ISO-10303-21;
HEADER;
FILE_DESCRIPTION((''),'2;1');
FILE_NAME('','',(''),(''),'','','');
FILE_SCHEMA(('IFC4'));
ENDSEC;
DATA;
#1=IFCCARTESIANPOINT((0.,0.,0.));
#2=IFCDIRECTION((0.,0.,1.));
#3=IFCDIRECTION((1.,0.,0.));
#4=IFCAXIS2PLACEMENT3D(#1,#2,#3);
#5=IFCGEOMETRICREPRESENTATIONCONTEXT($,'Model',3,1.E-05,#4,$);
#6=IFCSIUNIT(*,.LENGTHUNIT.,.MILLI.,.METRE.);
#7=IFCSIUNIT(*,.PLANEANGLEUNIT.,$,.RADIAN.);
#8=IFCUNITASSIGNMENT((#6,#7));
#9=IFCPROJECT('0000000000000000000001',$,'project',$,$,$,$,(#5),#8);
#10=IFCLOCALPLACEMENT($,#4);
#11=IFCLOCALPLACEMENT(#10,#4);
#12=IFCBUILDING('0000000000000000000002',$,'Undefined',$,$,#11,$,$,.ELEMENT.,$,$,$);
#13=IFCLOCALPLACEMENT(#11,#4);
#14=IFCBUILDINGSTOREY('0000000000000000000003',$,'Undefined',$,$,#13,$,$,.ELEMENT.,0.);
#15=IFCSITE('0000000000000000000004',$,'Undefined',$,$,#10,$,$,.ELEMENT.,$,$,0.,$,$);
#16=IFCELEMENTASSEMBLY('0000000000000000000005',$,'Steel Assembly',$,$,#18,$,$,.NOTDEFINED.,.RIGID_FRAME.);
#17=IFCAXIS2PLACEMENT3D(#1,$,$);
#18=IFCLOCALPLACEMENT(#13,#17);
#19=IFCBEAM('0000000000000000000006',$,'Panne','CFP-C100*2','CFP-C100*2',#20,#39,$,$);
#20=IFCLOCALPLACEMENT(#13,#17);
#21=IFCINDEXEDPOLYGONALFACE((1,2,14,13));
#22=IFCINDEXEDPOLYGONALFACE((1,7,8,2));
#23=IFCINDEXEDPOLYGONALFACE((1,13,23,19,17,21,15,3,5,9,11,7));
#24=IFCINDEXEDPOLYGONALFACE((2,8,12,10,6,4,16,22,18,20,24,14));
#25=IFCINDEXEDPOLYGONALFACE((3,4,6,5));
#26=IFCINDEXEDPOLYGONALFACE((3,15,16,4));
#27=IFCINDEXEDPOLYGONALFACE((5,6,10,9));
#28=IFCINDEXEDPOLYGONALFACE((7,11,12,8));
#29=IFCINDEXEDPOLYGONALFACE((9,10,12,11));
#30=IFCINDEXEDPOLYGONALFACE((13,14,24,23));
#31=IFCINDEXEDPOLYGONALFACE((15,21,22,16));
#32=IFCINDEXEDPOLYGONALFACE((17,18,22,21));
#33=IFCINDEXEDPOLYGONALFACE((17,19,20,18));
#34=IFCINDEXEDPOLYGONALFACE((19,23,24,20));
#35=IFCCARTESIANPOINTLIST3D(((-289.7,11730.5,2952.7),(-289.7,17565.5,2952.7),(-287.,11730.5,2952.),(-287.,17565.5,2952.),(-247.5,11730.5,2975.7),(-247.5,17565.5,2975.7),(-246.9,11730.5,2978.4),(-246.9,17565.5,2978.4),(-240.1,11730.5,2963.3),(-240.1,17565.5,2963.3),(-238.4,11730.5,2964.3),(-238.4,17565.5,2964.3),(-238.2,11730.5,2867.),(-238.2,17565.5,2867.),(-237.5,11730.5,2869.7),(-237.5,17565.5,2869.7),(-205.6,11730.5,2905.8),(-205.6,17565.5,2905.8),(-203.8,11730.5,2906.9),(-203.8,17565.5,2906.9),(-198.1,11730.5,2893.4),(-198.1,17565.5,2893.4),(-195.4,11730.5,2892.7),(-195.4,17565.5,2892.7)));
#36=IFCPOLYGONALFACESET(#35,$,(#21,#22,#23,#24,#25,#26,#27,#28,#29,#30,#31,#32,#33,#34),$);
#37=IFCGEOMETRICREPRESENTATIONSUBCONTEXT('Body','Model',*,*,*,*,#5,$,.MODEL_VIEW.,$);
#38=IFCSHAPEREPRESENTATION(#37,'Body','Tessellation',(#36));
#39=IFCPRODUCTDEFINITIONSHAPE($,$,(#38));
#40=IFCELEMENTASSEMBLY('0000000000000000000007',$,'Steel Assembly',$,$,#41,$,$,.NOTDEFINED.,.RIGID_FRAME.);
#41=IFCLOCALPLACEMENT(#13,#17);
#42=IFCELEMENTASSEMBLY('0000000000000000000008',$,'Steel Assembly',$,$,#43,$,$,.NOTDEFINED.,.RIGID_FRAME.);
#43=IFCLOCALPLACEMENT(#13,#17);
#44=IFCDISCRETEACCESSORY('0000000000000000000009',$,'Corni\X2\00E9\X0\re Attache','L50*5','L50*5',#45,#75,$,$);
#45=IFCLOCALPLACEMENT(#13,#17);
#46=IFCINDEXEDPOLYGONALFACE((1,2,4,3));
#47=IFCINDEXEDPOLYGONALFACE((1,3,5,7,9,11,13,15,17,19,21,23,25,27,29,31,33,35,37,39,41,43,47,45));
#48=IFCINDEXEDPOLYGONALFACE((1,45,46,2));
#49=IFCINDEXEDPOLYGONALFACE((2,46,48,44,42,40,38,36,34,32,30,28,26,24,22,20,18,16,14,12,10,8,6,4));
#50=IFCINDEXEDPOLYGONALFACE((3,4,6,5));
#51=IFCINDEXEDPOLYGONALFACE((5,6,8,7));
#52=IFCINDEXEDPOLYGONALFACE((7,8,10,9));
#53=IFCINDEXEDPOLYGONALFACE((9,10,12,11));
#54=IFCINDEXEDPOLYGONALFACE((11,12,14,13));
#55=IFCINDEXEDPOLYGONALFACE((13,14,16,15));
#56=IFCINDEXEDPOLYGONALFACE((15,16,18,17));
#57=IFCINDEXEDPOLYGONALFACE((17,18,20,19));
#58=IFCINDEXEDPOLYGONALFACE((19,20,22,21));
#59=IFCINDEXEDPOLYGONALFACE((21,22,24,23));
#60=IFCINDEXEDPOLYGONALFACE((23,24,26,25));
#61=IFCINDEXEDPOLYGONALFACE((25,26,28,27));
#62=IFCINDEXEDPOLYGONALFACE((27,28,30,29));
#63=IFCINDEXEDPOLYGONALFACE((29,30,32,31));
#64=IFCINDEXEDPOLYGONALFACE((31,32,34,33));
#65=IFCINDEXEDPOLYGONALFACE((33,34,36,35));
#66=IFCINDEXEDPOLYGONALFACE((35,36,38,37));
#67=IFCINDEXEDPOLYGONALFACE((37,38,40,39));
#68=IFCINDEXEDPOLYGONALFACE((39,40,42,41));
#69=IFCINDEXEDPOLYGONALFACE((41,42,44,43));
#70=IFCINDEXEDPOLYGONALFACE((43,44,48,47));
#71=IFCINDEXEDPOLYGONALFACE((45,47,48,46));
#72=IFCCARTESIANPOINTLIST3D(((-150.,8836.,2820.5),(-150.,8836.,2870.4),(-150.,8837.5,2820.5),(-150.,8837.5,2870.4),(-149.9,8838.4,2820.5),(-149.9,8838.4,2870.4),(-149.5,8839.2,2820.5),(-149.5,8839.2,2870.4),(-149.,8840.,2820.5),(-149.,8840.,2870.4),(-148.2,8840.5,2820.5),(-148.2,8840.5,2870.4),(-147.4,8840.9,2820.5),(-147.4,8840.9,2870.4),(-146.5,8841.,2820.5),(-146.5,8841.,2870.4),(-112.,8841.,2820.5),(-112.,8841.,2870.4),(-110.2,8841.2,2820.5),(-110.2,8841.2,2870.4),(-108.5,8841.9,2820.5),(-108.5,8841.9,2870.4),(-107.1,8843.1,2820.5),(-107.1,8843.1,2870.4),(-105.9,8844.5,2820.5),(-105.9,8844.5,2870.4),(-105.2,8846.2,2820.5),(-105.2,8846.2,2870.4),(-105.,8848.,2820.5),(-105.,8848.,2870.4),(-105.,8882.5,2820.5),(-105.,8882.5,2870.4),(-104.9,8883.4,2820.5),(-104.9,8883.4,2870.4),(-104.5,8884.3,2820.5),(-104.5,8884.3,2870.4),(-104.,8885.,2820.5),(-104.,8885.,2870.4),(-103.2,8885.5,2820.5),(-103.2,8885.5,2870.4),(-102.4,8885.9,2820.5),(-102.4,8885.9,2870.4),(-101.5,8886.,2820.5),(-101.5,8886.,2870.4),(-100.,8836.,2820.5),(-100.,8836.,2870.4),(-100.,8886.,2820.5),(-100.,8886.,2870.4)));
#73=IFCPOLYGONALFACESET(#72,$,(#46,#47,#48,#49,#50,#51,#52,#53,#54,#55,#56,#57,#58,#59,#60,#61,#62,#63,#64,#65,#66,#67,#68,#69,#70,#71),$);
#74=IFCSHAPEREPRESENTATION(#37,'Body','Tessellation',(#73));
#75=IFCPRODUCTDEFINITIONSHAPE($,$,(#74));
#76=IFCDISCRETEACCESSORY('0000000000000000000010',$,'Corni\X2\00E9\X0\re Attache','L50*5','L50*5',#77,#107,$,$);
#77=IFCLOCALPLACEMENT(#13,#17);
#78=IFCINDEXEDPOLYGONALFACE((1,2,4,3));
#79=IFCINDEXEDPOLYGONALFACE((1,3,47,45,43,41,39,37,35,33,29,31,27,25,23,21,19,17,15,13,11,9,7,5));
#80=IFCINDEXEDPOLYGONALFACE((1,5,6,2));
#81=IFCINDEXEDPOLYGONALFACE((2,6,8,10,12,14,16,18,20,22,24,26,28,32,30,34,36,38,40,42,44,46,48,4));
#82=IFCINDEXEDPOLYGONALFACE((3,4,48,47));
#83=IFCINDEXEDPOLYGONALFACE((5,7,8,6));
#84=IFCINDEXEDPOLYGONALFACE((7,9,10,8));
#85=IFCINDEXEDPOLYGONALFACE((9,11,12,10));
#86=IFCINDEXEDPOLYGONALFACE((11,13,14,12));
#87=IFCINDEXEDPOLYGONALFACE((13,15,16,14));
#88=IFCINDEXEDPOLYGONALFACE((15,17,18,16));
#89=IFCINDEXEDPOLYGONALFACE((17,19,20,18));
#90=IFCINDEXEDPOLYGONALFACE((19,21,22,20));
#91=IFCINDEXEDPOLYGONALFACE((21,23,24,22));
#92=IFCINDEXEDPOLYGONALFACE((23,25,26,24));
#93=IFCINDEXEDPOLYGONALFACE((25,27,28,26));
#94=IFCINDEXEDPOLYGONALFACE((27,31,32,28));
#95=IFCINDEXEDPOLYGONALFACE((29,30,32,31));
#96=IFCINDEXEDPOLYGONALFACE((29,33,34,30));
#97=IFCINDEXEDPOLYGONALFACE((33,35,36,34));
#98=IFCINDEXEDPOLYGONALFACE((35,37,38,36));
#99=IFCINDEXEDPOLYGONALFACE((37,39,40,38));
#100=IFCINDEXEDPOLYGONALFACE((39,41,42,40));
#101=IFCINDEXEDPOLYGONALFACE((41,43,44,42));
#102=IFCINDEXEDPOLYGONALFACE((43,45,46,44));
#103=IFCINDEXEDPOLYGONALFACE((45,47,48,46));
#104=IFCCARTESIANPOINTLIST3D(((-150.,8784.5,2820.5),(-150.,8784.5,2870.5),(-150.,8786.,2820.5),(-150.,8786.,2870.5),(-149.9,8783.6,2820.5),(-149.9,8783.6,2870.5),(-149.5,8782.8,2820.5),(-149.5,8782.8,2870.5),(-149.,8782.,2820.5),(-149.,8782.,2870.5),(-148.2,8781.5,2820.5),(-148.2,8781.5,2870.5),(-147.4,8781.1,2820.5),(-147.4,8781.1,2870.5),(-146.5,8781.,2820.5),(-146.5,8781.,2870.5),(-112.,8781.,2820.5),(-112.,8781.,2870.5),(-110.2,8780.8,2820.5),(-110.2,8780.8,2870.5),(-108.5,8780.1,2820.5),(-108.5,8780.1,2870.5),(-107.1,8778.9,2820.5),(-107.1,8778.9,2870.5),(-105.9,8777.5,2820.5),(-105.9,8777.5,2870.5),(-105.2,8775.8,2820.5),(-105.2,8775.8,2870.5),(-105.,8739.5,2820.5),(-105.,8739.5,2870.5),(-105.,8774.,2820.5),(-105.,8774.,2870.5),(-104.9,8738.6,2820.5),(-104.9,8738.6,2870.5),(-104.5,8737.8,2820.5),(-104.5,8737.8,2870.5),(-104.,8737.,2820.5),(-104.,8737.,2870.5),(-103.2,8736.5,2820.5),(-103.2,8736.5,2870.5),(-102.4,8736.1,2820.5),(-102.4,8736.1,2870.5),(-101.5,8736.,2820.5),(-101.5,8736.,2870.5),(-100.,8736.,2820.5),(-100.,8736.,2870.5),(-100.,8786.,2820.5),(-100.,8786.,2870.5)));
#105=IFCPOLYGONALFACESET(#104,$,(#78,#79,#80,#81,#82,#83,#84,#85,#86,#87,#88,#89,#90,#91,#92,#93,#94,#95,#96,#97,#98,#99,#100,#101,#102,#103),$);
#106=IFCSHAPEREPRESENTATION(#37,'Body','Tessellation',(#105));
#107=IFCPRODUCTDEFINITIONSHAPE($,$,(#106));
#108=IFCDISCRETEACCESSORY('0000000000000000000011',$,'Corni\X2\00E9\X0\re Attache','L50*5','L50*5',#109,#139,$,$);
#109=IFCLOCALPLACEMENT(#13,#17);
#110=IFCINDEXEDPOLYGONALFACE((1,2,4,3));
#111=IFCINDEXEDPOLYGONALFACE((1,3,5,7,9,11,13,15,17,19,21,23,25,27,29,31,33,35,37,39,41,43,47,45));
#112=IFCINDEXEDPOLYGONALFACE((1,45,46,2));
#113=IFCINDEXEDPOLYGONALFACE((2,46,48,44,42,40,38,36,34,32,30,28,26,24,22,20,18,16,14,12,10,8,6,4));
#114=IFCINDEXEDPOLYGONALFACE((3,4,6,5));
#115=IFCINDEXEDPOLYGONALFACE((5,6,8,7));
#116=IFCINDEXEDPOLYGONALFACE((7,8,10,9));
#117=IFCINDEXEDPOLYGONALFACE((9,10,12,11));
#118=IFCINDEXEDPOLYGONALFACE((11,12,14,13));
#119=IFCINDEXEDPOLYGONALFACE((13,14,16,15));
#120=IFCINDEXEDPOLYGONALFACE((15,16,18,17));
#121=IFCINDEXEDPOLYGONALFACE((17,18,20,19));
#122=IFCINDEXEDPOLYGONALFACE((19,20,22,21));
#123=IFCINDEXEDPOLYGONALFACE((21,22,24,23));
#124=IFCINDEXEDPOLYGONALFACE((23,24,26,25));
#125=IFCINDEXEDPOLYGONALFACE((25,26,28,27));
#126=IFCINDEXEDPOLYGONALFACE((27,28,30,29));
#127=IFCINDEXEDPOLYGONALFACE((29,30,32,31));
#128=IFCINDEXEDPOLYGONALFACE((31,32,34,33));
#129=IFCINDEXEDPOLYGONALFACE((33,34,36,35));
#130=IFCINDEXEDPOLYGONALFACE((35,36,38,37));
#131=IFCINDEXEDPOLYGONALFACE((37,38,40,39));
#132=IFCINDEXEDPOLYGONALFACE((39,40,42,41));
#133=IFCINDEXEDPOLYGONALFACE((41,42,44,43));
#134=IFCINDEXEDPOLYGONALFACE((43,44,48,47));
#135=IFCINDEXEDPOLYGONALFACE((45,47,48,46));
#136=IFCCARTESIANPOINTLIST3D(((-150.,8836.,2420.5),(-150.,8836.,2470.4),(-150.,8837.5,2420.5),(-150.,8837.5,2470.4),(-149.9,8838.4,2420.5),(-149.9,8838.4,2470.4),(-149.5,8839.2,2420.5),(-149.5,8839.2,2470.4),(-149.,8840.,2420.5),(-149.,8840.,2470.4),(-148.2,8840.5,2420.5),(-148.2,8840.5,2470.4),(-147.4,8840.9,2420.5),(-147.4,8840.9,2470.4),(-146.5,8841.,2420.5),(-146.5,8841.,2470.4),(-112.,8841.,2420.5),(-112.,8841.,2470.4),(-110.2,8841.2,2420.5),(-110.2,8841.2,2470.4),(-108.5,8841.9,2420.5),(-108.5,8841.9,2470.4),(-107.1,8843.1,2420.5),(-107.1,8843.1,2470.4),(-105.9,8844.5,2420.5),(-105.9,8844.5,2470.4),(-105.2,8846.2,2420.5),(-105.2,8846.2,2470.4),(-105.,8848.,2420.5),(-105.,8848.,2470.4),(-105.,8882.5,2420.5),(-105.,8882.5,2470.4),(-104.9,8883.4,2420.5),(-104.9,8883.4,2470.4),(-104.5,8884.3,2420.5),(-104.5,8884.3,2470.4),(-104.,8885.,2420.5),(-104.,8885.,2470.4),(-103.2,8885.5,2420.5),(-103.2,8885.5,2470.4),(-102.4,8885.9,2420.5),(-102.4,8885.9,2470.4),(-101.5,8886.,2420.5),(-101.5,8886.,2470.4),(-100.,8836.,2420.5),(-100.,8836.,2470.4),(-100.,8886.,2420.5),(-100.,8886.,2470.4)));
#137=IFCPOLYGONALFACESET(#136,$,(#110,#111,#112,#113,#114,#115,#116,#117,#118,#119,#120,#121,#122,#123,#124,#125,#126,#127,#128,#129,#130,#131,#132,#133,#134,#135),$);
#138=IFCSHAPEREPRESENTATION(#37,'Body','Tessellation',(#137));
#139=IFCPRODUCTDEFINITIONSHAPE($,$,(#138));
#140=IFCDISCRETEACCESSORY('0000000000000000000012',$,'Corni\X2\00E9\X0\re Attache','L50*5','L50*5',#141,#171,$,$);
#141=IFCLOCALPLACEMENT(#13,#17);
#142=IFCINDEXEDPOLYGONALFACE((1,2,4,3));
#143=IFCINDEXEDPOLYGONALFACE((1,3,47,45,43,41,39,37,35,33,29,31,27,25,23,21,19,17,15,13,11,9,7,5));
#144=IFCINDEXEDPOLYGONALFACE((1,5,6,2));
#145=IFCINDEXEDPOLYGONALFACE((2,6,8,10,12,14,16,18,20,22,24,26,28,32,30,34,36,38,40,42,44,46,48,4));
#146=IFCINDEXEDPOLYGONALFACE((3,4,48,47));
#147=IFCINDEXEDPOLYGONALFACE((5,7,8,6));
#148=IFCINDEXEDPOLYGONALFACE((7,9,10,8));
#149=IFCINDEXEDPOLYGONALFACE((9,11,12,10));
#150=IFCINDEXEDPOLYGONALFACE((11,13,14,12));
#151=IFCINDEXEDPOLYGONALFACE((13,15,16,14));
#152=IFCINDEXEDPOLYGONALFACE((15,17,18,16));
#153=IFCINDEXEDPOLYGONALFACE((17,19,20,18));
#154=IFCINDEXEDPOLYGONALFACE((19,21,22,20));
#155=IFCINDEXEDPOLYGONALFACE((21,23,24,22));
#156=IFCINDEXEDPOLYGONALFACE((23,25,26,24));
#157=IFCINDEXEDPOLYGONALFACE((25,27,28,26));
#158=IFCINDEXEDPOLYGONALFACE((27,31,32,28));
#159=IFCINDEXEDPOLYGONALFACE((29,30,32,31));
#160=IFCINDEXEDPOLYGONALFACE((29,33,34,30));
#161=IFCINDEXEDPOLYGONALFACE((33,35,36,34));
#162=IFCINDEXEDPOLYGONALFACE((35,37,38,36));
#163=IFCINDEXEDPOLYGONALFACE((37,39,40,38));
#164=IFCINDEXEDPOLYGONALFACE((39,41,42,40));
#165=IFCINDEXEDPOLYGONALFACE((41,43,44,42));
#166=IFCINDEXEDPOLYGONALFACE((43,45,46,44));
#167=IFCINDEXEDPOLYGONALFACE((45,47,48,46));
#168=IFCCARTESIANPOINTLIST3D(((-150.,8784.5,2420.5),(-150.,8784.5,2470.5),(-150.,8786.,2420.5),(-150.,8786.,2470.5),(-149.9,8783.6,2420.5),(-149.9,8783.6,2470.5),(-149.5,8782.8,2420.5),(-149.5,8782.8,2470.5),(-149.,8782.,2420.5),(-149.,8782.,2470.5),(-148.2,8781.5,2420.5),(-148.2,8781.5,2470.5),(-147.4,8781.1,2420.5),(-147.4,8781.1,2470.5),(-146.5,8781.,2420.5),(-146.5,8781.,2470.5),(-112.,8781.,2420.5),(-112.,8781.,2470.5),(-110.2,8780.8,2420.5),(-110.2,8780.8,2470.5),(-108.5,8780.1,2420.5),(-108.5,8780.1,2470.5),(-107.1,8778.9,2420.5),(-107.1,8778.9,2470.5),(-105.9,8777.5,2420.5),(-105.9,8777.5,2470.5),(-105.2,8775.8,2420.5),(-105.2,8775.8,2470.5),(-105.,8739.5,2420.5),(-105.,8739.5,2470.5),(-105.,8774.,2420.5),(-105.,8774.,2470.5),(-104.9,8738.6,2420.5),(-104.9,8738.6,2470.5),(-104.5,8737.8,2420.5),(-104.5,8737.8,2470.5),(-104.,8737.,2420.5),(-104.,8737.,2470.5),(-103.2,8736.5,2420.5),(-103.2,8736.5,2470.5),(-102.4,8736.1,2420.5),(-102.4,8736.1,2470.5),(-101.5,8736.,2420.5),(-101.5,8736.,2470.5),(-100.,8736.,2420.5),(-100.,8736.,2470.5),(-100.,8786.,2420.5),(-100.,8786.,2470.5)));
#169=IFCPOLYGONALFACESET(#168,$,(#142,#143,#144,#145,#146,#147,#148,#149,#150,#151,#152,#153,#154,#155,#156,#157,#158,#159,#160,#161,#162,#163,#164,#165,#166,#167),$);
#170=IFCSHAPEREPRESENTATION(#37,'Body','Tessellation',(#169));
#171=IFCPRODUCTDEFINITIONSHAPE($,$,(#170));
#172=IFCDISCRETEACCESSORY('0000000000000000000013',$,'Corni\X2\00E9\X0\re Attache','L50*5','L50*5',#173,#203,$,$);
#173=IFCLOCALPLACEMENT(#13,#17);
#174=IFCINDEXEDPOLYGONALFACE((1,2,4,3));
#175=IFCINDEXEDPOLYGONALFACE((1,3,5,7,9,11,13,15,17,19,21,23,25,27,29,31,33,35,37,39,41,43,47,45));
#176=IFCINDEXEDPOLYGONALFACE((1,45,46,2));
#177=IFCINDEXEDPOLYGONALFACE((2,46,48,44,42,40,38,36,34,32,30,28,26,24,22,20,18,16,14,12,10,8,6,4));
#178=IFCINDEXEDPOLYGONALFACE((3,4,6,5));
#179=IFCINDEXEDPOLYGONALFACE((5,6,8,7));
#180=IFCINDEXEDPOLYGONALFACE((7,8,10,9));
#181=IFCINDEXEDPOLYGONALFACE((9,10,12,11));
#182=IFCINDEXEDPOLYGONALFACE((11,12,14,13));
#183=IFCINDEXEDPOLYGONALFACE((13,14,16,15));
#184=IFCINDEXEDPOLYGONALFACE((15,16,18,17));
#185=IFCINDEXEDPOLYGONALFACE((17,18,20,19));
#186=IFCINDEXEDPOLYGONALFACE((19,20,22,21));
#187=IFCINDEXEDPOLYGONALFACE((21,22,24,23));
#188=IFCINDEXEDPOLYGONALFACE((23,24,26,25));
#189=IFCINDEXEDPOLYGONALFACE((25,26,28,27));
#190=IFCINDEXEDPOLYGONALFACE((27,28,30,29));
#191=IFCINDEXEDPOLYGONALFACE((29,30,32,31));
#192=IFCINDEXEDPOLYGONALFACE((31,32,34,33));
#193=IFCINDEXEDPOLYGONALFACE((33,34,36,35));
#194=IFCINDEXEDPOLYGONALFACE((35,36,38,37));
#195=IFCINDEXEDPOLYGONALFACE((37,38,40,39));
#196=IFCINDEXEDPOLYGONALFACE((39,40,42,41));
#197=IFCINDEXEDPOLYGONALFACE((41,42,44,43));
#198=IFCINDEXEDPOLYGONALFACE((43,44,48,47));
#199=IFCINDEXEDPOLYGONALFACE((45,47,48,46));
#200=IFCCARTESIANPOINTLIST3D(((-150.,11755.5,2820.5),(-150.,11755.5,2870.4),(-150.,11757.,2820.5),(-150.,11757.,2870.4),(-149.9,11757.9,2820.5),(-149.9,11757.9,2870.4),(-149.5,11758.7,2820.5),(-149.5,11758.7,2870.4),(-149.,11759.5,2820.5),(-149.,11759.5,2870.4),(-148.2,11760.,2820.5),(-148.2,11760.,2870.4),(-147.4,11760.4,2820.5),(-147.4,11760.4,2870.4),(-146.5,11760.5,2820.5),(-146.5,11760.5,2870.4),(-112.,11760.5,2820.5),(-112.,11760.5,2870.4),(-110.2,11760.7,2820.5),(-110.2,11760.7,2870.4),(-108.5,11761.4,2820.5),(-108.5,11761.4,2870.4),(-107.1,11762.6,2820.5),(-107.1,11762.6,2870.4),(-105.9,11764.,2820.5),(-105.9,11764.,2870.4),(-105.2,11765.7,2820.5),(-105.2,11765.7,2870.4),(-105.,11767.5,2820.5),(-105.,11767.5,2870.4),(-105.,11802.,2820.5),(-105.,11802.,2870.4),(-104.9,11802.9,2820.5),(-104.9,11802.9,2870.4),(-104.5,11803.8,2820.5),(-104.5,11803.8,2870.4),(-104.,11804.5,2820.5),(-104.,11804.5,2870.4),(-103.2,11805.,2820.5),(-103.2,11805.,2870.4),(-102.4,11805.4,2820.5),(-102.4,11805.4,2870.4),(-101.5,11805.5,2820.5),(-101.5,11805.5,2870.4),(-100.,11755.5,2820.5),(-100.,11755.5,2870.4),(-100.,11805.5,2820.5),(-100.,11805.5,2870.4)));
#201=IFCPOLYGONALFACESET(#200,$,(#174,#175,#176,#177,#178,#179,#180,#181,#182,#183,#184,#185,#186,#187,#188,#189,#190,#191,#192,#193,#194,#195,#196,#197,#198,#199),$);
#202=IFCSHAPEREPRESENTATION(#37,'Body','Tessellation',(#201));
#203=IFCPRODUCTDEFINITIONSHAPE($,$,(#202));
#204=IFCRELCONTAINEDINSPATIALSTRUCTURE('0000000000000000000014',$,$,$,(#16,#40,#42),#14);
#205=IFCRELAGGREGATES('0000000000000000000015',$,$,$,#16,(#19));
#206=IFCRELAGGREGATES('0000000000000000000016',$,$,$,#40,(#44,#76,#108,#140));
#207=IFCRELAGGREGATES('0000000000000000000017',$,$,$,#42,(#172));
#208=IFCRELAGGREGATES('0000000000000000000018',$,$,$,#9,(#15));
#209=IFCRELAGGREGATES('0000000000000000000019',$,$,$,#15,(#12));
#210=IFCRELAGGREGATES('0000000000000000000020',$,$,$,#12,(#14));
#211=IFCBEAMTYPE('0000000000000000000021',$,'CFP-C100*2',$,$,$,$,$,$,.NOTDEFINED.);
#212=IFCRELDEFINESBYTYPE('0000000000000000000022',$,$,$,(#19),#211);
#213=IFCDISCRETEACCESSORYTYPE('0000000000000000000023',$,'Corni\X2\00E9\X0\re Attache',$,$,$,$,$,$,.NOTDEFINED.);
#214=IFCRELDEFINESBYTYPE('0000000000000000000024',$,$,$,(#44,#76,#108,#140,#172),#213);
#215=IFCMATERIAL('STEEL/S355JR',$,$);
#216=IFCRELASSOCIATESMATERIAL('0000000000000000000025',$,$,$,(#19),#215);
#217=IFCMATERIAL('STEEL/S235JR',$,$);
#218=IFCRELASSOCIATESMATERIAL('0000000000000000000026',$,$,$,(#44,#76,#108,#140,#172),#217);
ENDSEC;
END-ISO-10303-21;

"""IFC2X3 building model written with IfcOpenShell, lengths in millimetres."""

from ifc_helpers import new_model, si_unit, frame, origin_with_axes, origin_2d_with_axis, place, context, subcontext, project, spatial, l_section, c_section, extrude, material, type_object, element, aggregate, save


model = new_model("IFC2X3")

# Units and contexts
model_context = context("Model", 3, precision=1e-05, world=origin_with_axes())
body_context = subcontext(model_context, "Body", "Model", "MODEL_VIEW")
ifc_project = project(units=[si_unit("LENGTHUNIT", "METRE", prefix="MILLI"), si_unit("PLANEANGLEUNIT", "RADIAN")], contexts=[model_context])

# Site, building, storey
site_placement = place(None, origin_with_axes())
site = spatial("IfcSite", under=ifc_project, at=site_placement, Name="Undefined", CompositionType="ELEMENT", RefElevation=0.0)
building_placement = place(site_placement, origin_with_axes())
building = spatial("IfcBuilding", under=site, at=building_placement, Name="Undefined", CompositionType="ELEMENT")
storey_placement = place(building_placement, origin_with_axes())
storey = spatial("IfcBuildingStorey", under=building, at=storey_placement, Name="Undefined", CompositionType="ELEMENT", Elevation=0.0)

# Element assembly, beam
assembly_1_placement = place(storey_placement, origin_with_axes())
assembly_1 = element("IfcElementAssembly", 1, at=assembly_1_placement, inside=storey, Name="Steel Assembly", AssemblyPlace="NOTDEFINED", PredefinedType="RIGID_FRAME")
ifc_material_1 = material(Name="STEEL/S355JR")
beam_type = type_object("IfcBeamType", Name="CFP-C100*2", PredefinedType="NOTDEFINED")
beam_placement = place(assembly_1_placement, frame((-242.5, 11730.5, 2922.7), z_axis=(-0.515036, 0.0, 0.857169), x_axis=(0.0, 1.0, 0.0)))
beam = element("IfcBeam", 2, at=beam_placement, type_object=beam_type, material=ifc_material_1, Name="Panne", Description="CFP-C100*2", ObjectType="CFP-C100*2", context=body_context, shape_type="SweptSolid", body=[
    extrude(c_section(Depth=100.0, Width=50.0, WallThickness=2.0, Girth=16.5, at=origin_2d_with_axis()), frame((5835.0, 0.0, 0.0), z_axis=(-1.0, 0.0, 0.0), x_axis=(0.0, -1.0, 0.0)), (0.0, 0.0, 1.0), 5835.0),
])

# Element assemblies
assembly_2_placement = place(storey_placement, origin_with_axes())
assembly_2 = element("IfcElementAssembly", 3, at=assembly_2_placement, inside=storey, Name="Steel Assembly", AssemblyPlace="NOTDEFINED", PredefinedType="RIGID_FRAME")
ifc_material_2 = material(Name="STEEL/S235JR")
assembly_3_placement = place(storey_placement, origin_with_axes())
assembly_3 = element("IfcElementAssembly", 4, at=assembly_3_placement, inside=storey, Name="Steel Assembly", AssemblyPlace="NOTDEFINED", PredefinedType="RIGID_FRAME")

# Discrete accessories
discrete_accessory_type_1 = type_object("IfcDiscreteAccessoryType", Name="Corniére Attache")
discrete_accessory_1_placement = place(assembly_2_placement, frame((-125.0, 8861.0, 2870.4), z_axis=(-1.0, 0.0, 0.0), x_axis=(0.0, 0.0, -1.0)))
discrete_accessory_1 = element("IfcDiscreteAccessory", 5, at=discrete_accessory_1_placement, type_object=discrete_accessory_type_1, material=ifc_material_2, Name="Corniére Attache", Description="L50*5", ObjectType="L50*5", context=body_context, shape_type="SweptSolid", body=[
    extrude(l_section(Depth=50.0, Width=50.0, Thickness=5.0, FilletRadius=7.0, EdgeRadius=3.5, at=origin_2d_with_axis()), frame((49.9, 0.0, 0.0), z_axis=(-1.0, 0.0, 0.0), x_axis=(0.0, -1.0, 0.0)), (0.0, 0.0, 1.0), 49.9),
])
discrete_accessory_2_placement = place(assembly_2_placement, frame((-125.0, 8761.0, 2820.5), z_axis=(0.0, 0.0, 1.0), x_axis=(1.0, 0.0, 0.0)))
discrete_accessory_2 = element("IfcDiscreteAccessory", 6, at=discrete_accessory_2_placement, type_object=discrete_accessory_type_1, material=ifc_material_2, Name="Corniére Attache", Description="L50*5", ObjectType="L50*5", context=body_context, shape_type="SweptSolid", body=[
    extrude(l_section(Depth=50.0, Width=50.0, Thickness=5.0, FilletRadius=7.0, EdgeRadius=3.5, at=origin_2d_with_axis()), frame((0.0, 0.0, 50.0), z_axis=(0.0, 0.0, -1.0), x_axis=(0.0, -1.0, 0.0)), (0.0, 0.0, 1.0), 50.0),
])
discrete_accessory_3_placement = place(assembly_2_placement, frame((-125.0, 8861.0, 2470.4), z_axis=(-1.0, 0.0, 0.0), x_axis=(0.0, 0.0, -1.0)))
discrete_accessory_3 = element("IfcDiscreteAccessory", 7, at=discrete_accessory_3_placement, type_object=discrete_accessory_type_1, material=ifc_material_2, Name="Corniére Attache", Description="L50*5", ObjectType="L50*5", context=body_context, shape_type="SweptSolid", body=[
    extrude(l_section(Depth=50.0, Width=50.0, Thickness=5.0, FilletRadius=7.0, EdgeRadius=3.5, at=origin_2d_with_axis()), frame((49.9, 0.0, 0.0), z_axis=(-1.0, 0.0, 0.0), x_axis=(0.0, -1.0, 0.0)), (0.0, 0.0, 1.0), 49.9),
])
discrete_accessory_4_placement = place(assembly_2_placement, frame((-125.0, 8761.0, 2420.5), z_axis=(0.0, 0.0, 1.0), x_axis=(1.0, 0.0, 0.0)))
discrete_accessory_4 = element("IfcDiscreteAccessory", 8, at=discrete_accessory_4_placement, type_object=discrete_accessory_type_1, material=ifc_material_2, Name="Corniére Attache", Description="L50*5", ObjectType="L50*5", context=body_context, shape_type="SweptSolid", body=[
    extrude(l_section(Depth=50.0, Width=50.0, Thickness=5.0, FilletRadius=7.0, EdgeRadius=3.5, at=origin_2d_with_axis()), frame((0.0, 0.0, 50.0), z_axis=(0.0, 0.0, -1.0), x_axis=(0.0, -1.0, 0.0)), (0.0, 0.0, 1.0), 50.0),
])
discrete_accessory_5_placement = place(assembly_3_placement, frame((-125.0, 11780.5, 2870.4), z_axis=(-1.0, 0.0, 0.0), x_axis=(0.0, 0.0, -1.0)))
discrete_accessory_5 = element("IfcDiscreteAccessory", 9, at=discrete_accessory_5_placement, type_object=discrete_accessory_type_1, material=ifc_material_2, Name="Corniére Attache", Description="L50*5", ObjectType="L50*5", context=body_context, shape_type="SweptSolid", body=[
    extrude(l_section(Depth=50.0, Width=50.0, Thickness=5.0, FilletRadius=7.0, EdgeRadius=3.5, at=origin_2d_with_axis()), frame((49.9, 0.0, 0.0), z_axis=(-1.0, 0.0, 0.0), x_axis=(0.0, -1.0, 0.0)), (0.0, 0.0, 1.0), 49.9),
])

aggregate(assembly_1, [beam])

aggregate(assembly_2, [discrete_accessory_1, discrete_accessory_2, discrete_accessory_3, discrete_accessory_4])
aggregate(assembly_3, [discrete_accessory_5])

save(model, "model.ifc")
